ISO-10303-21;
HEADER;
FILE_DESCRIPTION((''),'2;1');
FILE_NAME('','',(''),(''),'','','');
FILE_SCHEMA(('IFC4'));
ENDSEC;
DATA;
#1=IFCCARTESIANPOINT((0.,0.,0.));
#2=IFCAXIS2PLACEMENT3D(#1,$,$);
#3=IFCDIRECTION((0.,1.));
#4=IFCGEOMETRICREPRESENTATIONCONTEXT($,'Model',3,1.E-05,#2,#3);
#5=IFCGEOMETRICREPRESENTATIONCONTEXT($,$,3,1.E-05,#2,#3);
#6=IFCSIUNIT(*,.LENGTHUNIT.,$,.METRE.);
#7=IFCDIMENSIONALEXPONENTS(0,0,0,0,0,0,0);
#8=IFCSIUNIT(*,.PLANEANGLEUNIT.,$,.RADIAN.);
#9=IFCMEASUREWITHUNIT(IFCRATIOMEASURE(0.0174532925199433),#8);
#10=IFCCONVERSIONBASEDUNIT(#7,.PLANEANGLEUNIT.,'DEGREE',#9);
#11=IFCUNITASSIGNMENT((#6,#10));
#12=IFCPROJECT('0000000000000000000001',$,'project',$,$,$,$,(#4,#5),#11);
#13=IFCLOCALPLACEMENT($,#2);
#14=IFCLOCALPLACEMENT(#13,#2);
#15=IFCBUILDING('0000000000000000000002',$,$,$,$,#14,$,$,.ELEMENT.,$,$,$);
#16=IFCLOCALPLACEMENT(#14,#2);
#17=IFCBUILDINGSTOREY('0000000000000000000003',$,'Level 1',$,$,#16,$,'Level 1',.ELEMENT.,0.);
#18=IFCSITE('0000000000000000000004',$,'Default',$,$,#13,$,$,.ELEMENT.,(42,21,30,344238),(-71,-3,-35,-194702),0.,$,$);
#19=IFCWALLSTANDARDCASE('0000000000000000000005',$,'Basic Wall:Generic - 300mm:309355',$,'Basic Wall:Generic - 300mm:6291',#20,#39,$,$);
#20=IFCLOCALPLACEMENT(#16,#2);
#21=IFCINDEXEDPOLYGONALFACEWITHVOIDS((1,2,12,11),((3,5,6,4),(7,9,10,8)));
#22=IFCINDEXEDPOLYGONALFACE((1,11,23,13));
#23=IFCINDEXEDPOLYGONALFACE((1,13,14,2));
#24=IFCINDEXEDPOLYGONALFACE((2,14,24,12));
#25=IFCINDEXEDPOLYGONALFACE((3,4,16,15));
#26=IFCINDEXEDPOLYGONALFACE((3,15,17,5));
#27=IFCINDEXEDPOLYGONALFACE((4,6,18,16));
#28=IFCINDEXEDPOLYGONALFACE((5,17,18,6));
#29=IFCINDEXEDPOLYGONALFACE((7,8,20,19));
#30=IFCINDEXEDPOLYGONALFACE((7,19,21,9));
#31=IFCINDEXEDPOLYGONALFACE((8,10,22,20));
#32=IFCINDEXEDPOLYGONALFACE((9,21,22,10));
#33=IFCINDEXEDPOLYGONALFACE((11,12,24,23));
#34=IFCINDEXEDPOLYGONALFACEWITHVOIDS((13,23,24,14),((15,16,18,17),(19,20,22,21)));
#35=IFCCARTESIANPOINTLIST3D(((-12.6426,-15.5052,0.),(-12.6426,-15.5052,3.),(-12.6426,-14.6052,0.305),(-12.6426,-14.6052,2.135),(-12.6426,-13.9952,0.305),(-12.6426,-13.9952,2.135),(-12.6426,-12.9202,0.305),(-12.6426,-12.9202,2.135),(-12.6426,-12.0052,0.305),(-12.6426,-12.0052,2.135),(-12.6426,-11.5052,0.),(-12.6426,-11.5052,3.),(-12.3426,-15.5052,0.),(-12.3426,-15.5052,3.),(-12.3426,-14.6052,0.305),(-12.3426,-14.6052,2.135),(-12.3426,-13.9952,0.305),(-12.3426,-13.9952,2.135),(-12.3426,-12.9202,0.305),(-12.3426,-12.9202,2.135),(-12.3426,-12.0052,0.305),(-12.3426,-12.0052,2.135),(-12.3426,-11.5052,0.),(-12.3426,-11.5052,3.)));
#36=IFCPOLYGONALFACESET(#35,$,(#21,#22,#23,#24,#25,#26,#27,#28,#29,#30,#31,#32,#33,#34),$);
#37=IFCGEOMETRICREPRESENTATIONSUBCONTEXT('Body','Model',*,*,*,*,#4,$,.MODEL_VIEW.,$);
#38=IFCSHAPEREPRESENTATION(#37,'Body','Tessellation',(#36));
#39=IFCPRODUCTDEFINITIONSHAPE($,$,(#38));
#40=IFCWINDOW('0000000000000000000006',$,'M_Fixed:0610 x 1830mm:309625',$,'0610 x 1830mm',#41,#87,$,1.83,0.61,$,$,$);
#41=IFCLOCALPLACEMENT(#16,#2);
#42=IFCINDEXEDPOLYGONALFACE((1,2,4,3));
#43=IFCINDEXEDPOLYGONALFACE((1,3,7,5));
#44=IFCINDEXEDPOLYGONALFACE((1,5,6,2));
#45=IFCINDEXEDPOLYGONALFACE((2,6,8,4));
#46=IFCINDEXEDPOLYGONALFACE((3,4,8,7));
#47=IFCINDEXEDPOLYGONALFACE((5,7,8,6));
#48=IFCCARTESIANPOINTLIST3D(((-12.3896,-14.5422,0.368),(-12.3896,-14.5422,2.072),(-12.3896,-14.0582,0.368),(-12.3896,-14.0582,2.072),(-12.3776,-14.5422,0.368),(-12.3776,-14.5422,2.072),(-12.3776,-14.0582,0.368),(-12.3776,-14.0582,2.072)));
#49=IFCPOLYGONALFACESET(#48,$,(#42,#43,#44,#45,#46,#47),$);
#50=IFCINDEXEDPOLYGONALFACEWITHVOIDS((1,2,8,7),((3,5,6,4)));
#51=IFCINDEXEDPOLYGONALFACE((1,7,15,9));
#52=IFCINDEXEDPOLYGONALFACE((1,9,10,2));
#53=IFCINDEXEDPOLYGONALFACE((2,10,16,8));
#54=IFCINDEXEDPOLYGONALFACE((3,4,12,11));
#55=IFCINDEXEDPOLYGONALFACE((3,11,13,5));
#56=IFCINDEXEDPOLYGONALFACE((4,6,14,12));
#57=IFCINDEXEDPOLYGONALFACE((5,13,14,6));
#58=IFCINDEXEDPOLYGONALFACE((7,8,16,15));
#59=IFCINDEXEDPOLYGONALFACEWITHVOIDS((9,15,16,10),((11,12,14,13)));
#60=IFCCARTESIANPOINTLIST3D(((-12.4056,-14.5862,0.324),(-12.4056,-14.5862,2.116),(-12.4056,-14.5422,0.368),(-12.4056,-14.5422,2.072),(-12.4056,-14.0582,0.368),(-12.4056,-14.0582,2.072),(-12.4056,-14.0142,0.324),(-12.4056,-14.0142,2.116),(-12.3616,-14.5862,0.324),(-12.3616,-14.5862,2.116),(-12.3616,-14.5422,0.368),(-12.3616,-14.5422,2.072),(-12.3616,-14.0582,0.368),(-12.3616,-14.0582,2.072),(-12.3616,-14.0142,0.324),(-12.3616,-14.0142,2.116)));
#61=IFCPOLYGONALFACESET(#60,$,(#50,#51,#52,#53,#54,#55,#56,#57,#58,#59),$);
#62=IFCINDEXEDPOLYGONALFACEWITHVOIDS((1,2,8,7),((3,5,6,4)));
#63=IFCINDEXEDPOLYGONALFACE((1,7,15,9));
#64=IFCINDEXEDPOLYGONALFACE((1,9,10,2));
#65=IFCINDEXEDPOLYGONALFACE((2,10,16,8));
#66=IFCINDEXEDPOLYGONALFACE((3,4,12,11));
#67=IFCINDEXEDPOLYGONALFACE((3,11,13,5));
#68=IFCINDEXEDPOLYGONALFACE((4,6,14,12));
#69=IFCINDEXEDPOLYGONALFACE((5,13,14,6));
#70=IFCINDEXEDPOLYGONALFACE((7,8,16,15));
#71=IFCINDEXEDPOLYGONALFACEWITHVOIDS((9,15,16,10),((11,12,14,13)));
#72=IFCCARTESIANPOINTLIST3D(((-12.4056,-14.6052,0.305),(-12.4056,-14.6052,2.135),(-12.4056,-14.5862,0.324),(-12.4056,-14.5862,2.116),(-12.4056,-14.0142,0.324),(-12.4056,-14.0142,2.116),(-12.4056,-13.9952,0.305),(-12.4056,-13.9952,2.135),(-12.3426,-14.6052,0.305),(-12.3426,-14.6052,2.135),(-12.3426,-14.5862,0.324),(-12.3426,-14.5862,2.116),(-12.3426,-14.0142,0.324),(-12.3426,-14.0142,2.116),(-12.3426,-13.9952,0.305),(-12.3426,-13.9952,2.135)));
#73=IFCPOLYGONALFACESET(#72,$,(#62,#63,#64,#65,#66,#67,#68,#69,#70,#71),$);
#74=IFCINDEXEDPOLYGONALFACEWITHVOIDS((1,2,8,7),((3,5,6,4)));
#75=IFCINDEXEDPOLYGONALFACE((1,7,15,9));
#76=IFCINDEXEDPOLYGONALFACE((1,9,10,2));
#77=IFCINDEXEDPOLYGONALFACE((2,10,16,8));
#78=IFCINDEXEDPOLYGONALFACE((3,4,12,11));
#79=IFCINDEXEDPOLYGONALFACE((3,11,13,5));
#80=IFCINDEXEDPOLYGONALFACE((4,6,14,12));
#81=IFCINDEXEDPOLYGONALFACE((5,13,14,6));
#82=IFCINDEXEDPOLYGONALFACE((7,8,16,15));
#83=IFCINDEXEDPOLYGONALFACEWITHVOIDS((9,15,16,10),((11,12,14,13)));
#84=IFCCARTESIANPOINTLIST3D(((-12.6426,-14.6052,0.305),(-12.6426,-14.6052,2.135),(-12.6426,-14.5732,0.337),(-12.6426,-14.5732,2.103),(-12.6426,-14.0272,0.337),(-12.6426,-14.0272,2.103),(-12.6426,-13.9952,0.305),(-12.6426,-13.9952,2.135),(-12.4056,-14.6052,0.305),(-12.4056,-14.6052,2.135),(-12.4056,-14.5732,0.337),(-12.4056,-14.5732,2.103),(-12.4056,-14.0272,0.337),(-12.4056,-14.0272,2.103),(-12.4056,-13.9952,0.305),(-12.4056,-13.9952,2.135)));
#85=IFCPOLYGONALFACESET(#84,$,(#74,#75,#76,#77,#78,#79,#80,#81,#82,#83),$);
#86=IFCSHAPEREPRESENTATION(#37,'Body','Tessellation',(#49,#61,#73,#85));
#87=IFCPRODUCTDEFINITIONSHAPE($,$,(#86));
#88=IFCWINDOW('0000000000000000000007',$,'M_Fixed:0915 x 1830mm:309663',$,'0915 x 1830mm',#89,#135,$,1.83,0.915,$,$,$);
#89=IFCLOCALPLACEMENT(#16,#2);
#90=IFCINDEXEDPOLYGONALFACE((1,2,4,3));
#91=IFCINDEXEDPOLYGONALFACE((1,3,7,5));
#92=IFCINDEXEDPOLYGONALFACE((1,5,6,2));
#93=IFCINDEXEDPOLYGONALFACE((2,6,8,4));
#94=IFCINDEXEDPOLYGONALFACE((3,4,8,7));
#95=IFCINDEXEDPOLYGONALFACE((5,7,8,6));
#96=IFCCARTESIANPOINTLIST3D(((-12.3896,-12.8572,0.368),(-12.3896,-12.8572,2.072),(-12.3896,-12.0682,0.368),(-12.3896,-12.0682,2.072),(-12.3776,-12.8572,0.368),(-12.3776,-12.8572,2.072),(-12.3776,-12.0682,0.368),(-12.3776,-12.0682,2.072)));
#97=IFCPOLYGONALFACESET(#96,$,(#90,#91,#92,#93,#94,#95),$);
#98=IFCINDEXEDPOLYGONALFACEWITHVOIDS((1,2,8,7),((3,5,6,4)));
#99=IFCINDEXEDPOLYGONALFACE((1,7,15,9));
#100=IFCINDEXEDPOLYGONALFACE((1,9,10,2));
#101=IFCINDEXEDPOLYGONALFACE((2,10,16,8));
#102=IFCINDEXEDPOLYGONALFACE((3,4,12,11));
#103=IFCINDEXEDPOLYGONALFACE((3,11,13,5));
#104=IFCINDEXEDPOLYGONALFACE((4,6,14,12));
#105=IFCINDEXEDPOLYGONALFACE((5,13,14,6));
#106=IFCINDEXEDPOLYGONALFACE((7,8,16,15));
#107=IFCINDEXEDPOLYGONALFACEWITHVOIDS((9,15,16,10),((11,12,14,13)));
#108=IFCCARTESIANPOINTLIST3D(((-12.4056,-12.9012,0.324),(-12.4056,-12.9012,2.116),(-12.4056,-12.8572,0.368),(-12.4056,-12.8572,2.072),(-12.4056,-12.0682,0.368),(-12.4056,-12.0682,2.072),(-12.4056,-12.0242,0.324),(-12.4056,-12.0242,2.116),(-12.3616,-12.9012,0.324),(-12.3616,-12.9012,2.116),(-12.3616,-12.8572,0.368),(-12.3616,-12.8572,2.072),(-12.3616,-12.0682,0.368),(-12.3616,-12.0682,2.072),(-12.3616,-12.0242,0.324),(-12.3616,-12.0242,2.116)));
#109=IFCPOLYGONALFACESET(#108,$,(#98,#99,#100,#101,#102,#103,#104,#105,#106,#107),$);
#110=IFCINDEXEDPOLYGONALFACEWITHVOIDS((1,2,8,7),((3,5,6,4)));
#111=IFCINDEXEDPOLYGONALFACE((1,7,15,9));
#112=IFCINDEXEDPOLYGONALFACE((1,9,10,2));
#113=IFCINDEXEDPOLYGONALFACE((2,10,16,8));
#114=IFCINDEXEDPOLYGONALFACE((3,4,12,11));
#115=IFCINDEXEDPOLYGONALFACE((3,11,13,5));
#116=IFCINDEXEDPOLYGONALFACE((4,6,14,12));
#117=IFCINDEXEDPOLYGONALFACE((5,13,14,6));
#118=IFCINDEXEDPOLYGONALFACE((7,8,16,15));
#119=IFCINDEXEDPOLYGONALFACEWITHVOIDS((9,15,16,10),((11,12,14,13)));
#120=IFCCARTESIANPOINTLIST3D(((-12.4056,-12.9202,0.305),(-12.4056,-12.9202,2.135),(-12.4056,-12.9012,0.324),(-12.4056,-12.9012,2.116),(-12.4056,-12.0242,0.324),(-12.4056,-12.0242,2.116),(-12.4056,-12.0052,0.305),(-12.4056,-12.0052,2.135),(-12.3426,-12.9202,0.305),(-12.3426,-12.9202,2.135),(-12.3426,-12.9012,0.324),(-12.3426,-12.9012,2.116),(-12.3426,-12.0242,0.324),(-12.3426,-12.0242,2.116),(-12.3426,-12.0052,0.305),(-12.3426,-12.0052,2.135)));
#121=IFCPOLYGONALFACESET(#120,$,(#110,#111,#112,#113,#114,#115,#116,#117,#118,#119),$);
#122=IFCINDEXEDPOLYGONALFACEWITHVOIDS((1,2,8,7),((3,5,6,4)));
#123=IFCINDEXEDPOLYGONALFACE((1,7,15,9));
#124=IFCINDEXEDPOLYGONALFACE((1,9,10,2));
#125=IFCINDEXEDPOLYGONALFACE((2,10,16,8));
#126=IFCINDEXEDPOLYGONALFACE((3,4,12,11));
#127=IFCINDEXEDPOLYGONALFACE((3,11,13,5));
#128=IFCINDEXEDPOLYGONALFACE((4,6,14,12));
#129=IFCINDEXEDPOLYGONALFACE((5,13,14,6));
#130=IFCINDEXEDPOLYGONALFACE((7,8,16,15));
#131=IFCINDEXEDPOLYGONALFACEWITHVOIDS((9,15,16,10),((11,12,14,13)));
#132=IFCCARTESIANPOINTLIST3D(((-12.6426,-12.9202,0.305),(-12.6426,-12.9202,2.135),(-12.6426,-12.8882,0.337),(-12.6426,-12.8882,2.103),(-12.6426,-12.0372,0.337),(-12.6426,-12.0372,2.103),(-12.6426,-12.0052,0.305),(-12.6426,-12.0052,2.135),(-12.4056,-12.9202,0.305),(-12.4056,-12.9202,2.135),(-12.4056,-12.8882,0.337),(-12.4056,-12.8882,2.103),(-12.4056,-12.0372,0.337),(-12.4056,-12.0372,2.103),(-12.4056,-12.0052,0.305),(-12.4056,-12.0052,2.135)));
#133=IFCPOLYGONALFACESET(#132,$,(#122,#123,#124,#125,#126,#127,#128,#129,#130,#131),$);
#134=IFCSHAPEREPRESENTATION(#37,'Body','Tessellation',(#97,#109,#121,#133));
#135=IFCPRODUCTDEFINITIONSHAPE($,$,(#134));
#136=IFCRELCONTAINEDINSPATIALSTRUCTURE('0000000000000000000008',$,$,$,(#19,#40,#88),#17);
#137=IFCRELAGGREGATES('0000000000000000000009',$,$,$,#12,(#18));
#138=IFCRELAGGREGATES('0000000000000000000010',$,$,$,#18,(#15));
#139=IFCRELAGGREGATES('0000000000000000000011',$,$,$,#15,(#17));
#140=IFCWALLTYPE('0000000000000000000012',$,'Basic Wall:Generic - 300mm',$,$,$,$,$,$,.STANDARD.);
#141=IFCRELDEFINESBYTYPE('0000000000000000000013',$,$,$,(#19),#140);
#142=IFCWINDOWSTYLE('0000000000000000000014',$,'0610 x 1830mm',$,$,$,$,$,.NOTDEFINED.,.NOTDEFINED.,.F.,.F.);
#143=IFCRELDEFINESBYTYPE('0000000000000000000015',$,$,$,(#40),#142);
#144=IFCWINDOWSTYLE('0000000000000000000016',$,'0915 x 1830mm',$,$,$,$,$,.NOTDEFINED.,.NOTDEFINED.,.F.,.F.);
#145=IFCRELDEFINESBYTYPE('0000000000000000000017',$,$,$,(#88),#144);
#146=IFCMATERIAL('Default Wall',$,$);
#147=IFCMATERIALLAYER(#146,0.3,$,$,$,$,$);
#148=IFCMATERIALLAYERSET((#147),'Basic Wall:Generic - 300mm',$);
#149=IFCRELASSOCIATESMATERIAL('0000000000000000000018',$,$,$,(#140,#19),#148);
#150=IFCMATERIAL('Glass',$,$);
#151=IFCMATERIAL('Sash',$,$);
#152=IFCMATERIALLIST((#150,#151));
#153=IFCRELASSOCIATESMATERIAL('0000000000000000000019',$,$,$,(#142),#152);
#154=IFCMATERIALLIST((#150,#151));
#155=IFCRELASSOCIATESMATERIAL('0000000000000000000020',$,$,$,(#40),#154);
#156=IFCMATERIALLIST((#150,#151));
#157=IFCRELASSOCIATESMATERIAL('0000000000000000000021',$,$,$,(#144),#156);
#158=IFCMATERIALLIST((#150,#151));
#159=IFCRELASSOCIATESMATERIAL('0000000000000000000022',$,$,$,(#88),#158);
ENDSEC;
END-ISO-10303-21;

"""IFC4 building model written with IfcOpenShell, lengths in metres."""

from ifc_helpers import new_model, entity, si_unit, converted_unit, direction, frame, frame_2d, origin, place, context, subcontext, project, spatial, polyline, rectangle, outline, extrude, source, transform, mapped, material, material_list, layer, layer_set, layer_usage, type_object, type_shapes, element, fill, save


model = new_model("IFC4")

# Units and contexts
model_context = context("Model", 3, precision=1e-05, world=origin(), true_north=direction((0.0, 1.0)))
context_of_model = context(None, 3, precision=1e-05, world=origin(), true_north=direction((0.0, 1.0)))
body_context = subcontext(model_context, "Body", "Model", "MODEL_VIEW")
ifc_project = project(units=[si_unit("LENGTHUNIT", "METRE"), converted_unit("PLANEANGLEUNIT", "DEGREE", entity("IfcRatioMeasure", 0.0174532925199433), si_unit("PLANEANGLEUNIT", "RADIAN"), dimensions=[0, 0, 0, 0, 0, 0, 0])], contexts=[model_context, context_of_model])

# Site, building, storey
site_placement = place(None, origin())
site = spatial("IfcSite", under=ifc_project, at=site_placement, Name="Default", CompositionType="ELEMENT", RefLatitude=(42, 21, 30, 344238), RefLongitude=(-71, -3, -35, -194702), RefElevation=0.0)
building_placement = place(site_placement, origin())
building = spatial("IfcBuilding", under=site, at=building_placement, CompositionType="ELEMENT")
storey_placement = place(building_placement, origin())
storey = spatial("IfcBuildingStorey", under=building, at=storey_placement, Name="Level 1", LongName="Level 1", CompositionType="ELEMENT", Elevation=0.0)

# Shared definitions
ifc_material_1 = material(Name="Default Wall")
ifc_layer = layer(ifc_material_1, 0.3)
ifc_layer_set = layer_set([ifc_layer], Name="Basic Wall:Generic - 300mm")
wall_type = type_object("IfcWallType", Name="Basic Wall:Generic - 300mm", PredefinedType="STANDARD", material=ifc_layer_set)

# Shared definitions
ifc_material_2 = material(Name="Glass")
ifc_material_3 = material(Name="Sash")
ifc_material_list_1 = material_list([ifc_material_2, ifc_material_3])
window_style_1 = type_object("IfcWindowStyle", Name="0610 x 1830mm", ConstructionType="NOTDEFINED", OperationType="NOTDEFINED", ParameterTakesPrecedence=False, Sizeable=False, material=ifc_material_list_1)
shared_shape_1 = source(origin(), body_context, "Body", "SweptSolid", [
    extrude(rectangle(XDim=0.012, YDim=0.484, at=frame_2d((0.0, 0.0), x_axis=(1.0, 0.0))), frame((0.305, 0.259, 0.063), z_axis=(0.0, 0.0, 1.0), x_axis=(0.0, -1.0, 0.0)), (0.0, 0.0, 1.0), 1.704),
    extrude(outline(polyline([(-0.286, -0.896), (0.286, -0.896), (0.286, 0.896), (-0.286, 0.896), (-0.286, -0.896)]), holes=[polyline([(-0.242, -0.852), (-0.242, 0.852), (0.242, 0.852), (0.242, -0.852), (-0.242, -0.852)])]), frame((0.305, 0.237, 0.915), z_axis=(0.0, 1.0, 0.0), x_axis=(1.0, 0.0, 0.0)), (0.0, 0.0, 1.0), 0.044),
    extrude(outline(polyline([(-0.305, -0.915), (0.305, -0.915), (0.305, 0.915), (-0.305, 0.915), (-0.305, -0.915)]), holes=[polyline([(-0.286, -0.896), (-0.286, 0.896), (0.286, 0.896), (0.286, -0.896), (-0.286, -0.896)])]), frame((0.305, 0.237, 0.915), z_axis=(0.0, 1.0, 0.0), x_axis=(1.0, 0.0, 0.0)), (0.0, 0.0, 1.0), 0.063),
    extrude(outline(polyline([(-0.305, -0.915), (0.305, -0.915), (0.305, 0.915), (-0.305, 0.915), (-0.305, -0.915)]), holes=[polyline([(-0.273, -0.883), (-0.273, 0.883), (0.273, 0.883), (0.273, -0.883), (-0.273, -0.883)])]), frame((0.305, 0.0, 0.915), z_axis=(0.0, 1.0, 0.0), x_axis=(1.0, 0.0, 0.0)), (0.0, 0.0, 1.0), 0.237),
])
type_shapes(window_style_1, [shared_shape_1])

# Wall, openings, windows
ifc_layer_usage_1 = layer_usage(ifc_layer_set, "AXIS2", "NEGATIVE", 0.15)
wall_1_placement = place(storey_placement, frame((-12.4926, -15.5052, 0.0), z_axis=(0.0, 0.0, 1.0), x_axis=(0.0, 1.0, 0.0)))
wall_1 = element("IfcWallStandardCase", 1, at=wall_1_placement, inside=storey, type_object=wall_type, material=ifc_layer_usage_1, Name="Basic Wall:Generic - 300mm:309355", ObjectType="Basic Wall:Generic - 300mm:6291", context=body_context, shape_type="SweptSolid", body=[
    extrude(rectangle(XDim=4.0, YDim=0.3, at=frame_2d((2.0, 0.0), x_axis=(-1.0, 0.0))), origin(), (0.0, 0.0, 1.0), 3.0),
])
opening_1_placement = place(wall_1_placement, frame((1.51, 0.15, 0.305)))
opening_1 = element("IfcOpeningElement", 2, at=opening_1_placement, cuts=wall_1, ObjectType="Opening", context=body_context, shape_type="SweptSolid", body=[
    extrude(rectangle(XDim=1.83, YDim=0.61, at=frame_2d((0.915, 0.305), x_axis=(1.0, 0.0))), frame((0.0, 0.0, 0.0), z_axis=(0.0, -1.0, 0.0), x_axis=(0.0, 0.0, 1.0)), (0.0, 0.0, 1.0), 0.3),
])
opening_2_placement = place(wall_1_placement, frame((3.5, 0.15, 0.305)))
opening_2 = element("IfcOpeningElement", 3, at=opening_2_placement, cuts=wall_1, ObjectType="Opening", context=body_context, shape_type="SweptSolid", body=[
    extrude(rectangle(XDim=1.83, YDim=0.915, at=frame_2d((0.915, 0.4575), x_axis=(1.0, 0.0))), frame((0.0, 0.0, 0.0), z_axis=(0.0, -1.0, 0.0), x_axis=(0.0, 0.0, 1.0)), (0.0, 0.0, 1.0), 0.3),
])
ifc_material_list_2 = material_list([ifc_material_2, ifc_material_3])
window_1_placement = place(opening_1_placement, frame((0.0, 0.0, 0.0), z_axis=(0.0, 0.0, 1.0), x_axis=(-1.0, 0.0, 0.0)))
window_1 = element("IfcWindow", 4, at=window_1_placement, inside=storey, type_object=window_style_1, material=ifc_material_list_2, Name="M_Fixed:0610 x 1830mm:309625", ObjectType="0610 x 1830mm", OverallHeight=1.83, OverallWidth=0.61, context=body_context, shape_type="MappedRepresentation", body=[
    mapped(shared_shape_1, transform((0.0, 0.0, 0.0), scale=1.0)),
])
fill(opening_1, window_1)
ifc_material_list_3 = material_list([ifc_material_2, ifc_material_3])
ifc_material_list_4 = material_list([ifc_material_2, ifc_material_3])
window_style_2 = type_object("IfcWindowStyle", Name="0915 x 1830mm", ConstructionType="NOTDEFINED", OperationType="NOTDEFINED", ParameterTakesPrecedence=False, Sizeable=False, material=ifc_material_list_4)
shared_shape_2 = source(origin(), body_context, "Body", "SweptSolid", [
    extrude(rectangle(XDim=0.012, YDim=0.789, at=frame_2d((0.0, 0.0), x_axis=(1.0, 0.0))), frame((0.4575, 0.259, 0.063), z_axis=(0.0, 0.0, 1.0), x_axis=(0.0, -1.0, 0.0)), (0.0, 0.0, 1.0), 1.704),
    extrude(outline(polyline([(-0.4385, -0.896), (0.4385, -0.896), (0.4385, 0.896), (-0.4385, 0.896), (-0.4385, -0.896)]), holes=[polyline([(-0.3945, -0.852), (-0.3945, 0.852), (0.3945, 0.852), (0.3945, -0.852), (-0.3945, -0.852)])]), frame((0.4575, 0.237, 0.915), z_axis=(0.0, 1.0, 0.0), x_axis=(1.0, 0.0, 0.0)), (0.0, 0.0, 1.0), 0.044),
    extrude(outline(polyline([(-0.4575, -0.915), (0.4575, -0.915), (0.4575, 0.915), (-0.4575, 0.915), (-0.4575, -0.915)]), holes=[polyline([(-0.4385, -0.896), (-0.4385, 0.896), (0.4385, 0.896), (0.4385, -0.896), (-0.4385, -0.896)])]), frame((0.4575, 0.237, 0.915), z_axis=(0.0, 1.0, 0.0), x_axis=(1.0, 0.0, 0.0)), (0.0, 0.0, 1.0), 0.063),
    extrude(outline(polyline([(-0.4575, -0.915), (0.4575, -0.915), (0.4575, 0.915), (-0.4575, 0.915), (-0.4575, -0.915)]), holes=[polyline([(-0.4255, -0.883), (-0.4255, 0.883), (0.4255, 0.883), (0.4255, -0.883), (-0.4255, -0.883)])]), frame((0.4575, 0.0, 0.915), z_axis=(0.0, 1.0, 0.0), x_axis=(1.0, 0.0, 0.0)), (0.0, 0.0, 1.0), 0.237),
])
type_shapes(window_style_2, [shared_shape_2])
window_2_placement = place(opening_2_placement, frame((0.0, 0.0, 0.0), z_axis=(0.0, 0.0, 1.0), x_axis=(-1.0, 0.0, 0.0)))
window_2 = element("IfcWindow", 5, at=window_2_placement, inside=storey, type_object=window_style_2, material=ifc_material_list_3, Name="M_Fixed:0915 x 1830mm:309663", ObjectType="0915 x 1830mm", OverallHeight=1.83, OverallWidth=0.915, context=body_context, shape_type="MappedRepresentation", body=[
    mapped(shared_shape_2, transform((0.0, 0.0, 0.0), scale=1.0)),
])
fill(opening_2, window_2)

save(model, "model.ifc")
